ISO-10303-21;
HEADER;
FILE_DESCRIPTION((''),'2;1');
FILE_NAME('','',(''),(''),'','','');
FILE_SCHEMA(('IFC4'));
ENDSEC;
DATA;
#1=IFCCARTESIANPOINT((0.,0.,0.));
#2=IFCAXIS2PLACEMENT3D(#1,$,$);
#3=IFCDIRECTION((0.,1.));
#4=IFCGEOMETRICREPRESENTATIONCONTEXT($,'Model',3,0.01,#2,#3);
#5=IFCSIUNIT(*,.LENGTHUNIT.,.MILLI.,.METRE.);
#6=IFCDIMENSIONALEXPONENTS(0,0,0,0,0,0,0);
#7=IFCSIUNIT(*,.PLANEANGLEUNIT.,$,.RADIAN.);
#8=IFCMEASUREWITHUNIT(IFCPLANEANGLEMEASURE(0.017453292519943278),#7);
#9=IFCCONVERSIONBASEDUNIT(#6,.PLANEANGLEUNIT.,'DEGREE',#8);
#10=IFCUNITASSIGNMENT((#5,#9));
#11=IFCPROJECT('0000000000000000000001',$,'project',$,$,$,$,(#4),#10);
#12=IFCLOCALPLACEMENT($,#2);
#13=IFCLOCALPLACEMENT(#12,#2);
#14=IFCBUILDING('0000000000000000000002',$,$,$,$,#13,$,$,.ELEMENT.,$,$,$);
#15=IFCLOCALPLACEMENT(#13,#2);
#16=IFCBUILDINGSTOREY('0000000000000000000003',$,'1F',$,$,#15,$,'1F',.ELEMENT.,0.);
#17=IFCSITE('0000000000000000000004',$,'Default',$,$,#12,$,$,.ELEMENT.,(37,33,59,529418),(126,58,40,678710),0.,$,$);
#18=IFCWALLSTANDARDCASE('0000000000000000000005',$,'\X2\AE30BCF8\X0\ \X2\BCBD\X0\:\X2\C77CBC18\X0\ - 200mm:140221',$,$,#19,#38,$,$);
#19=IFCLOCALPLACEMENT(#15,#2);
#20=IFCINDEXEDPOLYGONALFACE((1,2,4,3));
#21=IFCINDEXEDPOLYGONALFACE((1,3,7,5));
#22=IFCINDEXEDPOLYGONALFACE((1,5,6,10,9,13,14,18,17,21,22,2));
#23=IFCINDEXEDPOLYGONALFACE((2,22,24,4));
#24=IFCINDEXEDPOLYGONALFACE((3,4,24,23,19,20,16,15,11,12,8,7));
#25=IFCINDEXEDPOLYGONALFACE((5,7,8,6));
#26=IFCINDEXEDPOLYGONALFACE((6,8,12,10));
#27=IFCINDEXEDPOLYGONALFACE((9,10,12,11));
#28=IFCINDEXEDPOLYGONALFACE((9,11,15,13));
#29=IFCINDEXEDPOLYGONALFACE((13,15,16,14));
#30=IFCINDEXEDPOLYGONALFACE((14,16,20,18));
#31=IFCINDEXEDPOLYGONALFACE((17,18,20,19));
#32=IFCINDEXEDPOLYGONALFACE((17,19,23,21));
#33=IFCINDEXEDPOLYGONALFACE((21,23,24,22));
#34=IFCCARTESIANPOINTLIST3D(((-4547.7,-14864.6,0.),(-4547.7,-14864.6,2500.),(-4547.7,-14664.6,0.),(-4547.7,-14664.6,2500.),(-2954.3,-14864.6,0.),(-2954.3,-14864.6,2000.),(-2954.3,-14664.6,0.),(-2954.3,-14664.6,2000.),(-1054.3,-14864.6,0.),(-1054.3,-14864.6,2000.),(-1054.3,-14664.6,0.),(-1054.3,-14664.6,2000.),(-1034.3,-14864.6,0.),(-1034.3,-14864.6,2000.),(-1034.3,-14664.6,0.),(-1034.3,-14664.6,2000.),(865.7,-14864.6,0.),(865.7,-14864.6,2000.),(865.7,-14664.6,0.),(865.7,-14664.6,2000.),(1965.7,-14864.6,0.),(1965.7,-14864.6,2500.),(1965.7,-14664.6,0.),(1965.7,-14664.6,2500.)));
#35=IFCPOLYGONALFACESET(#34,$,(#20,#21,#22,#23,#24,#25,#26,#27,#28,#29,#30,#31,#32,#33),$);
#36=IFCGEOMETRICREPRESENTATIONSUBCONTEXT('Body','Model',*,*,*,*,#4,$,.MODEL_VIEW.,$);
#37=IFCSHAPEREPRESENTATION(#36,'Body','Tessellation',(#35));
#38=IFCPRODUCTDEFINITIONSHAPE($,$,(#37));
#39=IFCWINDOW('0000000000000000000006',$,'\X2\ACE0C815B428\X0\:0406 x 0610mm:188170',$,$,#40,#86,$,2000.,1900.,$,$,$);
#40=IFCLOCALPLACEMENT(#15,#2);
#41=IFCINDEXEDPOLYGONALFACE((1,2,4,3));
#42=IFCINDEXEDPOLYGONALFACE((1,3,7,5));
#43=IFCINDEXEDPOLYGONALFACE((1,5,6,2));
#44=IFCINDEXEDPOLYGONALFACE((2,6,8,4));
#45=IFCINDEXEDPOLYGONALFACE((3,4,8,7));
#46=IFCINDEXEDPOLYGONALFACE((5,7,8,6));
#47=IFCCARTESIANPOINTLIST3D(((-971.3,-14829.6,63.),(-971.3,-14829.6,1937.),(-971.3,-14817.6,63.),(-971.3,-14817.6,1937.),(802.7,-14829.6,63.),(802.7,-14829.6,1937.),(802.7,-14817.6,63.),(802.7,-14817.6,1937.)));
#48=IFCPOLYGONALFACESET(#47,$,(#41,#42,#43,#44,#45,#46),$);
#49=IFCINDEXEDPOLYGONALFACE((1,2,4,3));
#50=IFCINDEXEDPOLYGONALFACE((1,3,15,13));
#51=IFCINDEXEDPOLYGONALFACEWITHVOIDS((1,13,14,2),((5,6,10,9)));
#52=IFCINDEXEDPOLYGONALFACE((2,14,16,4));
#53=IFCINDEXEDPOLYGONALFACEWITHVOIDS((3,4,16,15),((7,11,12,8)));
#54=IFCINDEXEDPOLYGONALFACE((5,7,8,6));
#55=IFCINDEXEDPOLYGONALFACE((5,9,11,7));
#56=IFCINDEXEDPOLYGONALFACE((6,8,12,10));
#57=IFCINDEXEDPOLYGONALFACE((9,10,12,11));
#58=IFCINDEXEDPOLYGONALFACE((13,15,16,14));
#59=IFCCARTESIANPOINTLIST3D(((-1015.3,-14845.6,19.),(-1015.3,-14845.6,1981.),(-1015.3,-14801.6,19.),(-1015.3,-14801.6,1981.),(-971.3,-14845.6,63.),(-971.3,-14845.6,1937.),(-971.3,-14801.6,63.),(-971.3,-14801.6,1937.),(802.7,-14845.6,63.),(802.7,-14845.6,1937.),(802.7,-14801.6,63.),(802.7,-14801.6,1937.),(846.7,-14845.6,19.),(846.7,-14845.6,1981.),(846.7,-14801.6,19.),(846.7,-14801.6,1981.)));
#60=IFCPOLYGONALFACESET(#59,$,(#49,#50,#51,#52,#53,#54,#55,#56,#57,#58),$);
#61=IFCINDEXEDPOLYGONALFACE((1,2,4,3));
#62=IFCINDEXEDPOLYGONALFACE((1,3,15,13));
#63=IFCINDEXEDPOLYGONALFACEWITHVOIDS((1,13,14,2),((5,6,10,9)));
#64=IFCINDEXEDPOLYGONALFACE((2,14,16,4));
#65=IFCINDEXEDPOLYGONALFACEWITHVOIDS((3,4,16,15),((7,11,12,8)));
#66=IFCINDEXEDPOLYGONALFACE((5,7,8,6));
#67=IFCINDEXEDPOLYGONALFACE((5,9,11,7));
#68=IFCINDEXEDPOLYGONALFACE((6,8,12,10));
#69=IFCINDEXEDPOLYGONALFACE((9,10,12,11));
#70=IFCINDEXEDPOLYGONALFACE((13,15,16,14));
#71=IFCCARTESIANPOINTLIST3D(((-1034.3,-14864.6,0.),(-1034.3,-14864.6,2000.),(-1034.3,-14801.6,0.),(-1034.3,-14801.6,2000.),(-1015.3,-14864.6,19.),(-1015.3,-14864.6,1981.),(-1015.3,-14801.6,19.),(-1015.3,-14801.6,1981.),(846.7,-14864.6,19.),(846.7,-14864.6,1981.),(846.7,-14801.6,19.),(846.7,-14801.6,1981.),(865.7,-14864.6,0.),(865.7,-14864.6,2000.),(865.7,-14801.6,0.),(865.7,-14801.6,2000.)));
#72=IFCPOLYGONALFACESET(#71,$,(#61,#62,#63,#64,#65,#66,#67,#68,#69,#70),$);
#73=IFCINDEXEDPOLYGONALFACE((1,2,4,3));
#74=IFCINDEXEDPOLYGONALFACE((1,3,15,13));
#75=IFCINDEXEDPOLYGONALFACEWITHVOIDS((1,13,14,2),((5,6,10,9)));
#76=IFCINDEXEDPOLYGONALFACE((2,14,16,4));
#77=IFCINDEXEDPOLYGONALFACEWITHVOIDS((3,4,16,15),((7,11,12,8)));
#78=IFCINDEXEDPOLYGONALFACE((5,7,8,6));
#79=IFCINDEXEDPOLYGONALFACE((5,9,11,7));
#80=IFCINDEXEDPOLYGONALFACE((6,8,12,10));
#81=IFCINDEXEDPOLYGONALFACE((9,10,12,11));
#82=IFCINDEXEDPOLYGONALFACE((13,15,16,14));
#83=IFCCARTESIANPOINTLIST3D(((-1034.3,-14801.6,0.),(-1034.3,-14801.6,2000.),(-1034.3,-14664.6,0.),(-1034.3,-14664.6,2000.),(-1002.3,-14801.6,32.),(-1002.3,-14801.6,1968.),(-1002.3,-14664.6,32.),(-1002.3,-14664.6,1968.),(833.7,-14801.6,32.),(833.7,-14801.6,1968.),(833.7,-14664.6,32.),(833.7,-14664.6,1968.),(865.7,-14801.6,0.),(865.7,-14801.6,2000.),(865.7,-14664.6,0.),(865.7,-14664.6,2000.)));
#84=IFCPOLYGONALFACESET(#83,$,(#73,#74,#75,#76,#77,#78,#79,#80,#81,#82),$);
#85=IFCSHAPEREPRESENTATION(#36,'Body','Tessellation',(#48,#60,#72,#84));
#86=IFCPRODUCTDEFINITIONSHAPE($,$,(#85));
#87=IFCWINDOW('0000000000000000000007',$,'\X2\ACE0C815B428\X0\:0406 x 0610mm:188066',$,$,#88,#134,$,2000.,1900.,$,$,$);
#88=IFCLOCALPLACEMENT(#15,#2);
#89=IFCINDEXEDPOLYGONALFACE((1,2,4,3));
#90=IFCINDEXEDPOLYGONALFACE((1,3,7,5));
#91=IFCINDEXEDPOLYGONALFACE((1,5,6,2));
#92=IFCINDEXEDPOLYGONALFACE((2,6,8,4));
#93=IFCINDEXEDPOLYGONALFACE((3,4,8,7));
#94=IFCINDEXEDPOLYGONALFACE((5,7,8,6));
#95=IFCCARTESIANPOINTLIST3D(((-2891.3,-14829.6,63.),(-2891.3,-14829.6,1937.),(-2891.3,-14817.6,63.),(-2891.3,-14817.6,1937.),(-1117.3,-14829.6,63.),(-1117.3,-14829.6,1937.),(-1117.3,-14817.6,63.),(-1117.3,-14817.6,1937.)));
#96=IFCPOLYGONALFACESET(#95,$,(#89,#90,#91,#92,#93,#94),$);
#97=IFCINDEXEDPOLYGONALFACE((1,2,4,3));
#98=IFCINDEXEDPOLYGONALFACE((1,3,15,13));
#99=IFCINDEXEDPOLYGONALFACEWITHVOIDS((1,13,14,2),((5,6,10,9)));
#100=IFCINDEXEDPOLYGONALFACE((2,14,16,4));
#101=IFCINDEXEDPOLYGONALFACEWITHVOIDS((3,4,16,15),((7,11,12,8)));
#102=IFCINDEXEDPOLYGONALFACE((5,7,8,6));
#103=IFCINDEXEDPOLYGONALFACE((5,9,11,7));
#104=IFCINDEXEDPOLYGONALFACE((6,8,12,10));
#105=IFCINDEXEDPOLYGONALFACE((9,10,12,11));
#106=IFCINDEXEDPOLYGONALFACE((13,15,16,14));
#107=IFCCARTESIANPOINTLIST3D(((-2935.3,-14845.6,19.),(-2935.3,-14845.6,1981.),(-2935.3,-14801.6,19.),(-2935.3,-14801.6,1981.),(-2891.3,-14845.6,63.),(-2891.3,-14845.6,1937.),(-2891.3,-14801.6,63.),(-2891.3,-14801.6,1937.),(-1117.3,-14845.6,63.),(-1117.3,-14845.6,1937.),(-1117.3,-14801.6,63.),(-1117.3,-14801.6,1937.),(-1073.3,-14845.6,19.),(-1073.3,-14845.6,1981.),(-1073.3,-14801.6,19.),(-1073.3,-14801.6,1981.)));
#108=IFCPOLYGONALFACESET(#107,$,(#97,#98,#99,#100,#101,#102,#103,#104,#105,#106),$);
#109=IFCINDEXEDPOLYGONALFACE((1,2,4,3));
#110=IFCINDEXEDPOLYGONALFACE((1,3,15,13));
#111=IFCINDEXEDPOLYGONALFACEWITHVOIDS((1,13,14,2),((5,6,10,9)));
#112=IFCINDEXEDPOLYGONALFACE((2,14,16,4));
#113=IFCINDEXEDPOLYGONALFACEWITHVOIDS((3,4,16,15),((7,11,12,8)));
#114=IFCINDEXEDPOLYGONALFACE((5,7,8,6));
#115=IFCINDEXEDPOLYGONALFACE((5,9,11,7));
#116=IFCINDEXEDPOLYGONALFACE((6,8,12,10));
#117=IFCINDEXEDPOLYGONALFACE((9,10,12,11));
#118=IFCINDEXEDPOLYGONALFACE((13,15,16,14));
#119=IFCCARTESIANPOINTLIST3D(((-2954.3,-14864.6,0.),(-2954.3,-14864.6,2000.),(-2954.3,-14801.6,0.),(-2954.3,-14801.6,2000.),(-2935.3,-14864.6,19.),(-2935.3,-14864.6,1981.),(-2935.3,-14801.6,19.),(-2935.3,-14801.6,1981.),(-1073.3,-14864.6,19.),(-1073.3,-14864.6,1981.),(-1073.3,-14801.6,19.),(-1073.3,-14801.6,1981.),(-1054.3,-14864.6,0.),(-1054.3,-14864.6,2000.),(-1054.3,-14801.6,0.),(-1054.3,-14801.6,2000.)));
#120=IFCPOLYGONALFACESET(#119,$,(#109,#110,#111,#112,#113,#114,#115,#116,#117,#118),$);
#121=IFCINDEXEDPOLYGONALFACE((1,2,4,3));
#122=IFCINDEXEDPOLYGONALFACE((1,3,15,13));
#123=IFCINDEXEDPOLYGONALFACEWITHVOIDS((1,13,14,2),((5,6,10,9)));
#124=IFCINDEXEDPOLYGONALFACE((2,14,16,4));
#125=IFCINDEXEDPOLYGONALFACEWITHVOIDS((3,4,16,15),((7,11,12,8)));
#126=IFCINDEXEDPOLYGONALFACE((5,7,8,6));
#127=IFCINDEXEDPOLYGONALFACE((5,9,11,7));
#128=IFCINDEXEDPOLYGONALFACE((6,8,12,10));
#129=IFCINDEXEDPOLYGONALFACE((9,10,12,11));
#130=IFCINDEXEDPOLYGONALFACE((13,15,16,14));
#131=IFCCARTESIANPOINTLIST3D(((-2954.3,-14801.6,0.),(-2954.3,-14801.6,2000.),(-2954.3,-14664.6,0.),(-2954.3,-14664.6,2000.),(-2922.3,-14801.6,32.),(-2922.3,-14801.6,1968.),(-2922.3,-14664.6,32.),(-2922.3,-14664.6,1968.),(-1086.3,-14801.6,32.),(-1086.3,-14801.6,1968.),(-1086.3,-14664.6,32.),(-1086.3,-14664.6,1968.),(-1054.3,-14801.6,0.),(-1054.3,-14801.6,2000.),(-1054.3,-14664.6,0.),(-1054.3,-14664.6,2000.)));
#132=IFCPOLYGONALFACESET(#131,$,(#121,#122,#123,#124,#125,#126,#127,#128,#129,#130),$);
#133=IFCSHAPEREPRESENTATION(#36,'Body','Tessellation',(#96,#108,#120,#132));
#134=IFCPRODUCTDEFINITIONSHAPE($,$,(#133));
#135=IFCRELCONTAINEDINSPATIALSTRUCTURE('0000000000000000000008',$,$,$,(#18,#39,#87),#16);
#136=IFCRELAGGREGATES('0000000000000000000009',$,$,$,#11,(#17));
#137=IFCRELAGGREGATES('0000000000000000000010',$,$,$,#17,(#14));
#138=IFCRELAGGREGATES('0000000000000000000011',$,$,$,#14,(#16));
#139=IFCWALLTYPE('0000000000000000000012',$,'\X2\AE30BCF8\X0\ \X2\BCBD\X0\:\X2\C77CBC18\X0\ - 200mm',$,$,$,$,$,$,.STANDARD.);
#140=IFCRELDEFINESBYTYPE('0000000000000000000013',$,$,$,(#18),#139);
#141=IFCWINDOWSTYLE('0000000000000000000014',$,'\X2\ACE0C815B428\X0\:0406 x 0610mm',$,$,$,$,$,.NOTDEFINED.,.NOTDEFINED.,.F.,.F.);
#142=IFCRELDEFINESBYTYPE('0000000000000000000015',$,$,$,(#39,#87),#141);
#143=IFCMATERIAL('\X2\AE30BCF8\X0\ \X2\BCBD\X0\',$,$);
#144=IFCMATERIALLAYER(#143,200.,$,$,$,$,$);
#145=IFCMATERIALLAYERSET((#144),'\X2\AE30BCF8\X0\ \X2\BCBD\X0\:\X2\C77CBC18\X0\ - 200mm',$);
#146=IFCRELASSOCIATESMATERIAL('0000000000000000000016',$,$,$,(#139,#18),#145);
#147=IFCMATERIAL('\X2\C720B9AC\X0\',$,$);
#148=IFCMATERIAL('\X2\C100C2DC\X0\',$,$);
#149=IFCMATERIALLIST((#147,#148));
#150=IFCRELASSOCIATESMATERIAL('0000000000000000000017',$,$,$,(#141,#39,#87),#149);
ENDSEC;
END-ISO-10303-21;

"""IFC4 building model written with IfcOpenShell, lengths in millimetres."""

from ifc_helpers import new_model, entity, si_unit, converted_unit, direction, frame, frame_2d, origin, place, context, subcontext, project, spatial, polyline, rectangle, outline, extrude, source, transform, mapped, material, material_list, layer, layer_set, layer_usage, type_object, type_shapes, element, fill, save


model = new_model("IFC4")

# Units and contexts
model_context = context("Model", 3, precision=0.01, world=origin(), true_north=direction((0.0, 1.0)))
body_context = subcontext(model_context, "Body", "Model", "MODEL_VIEW")
ifc_project = project(units=[si_unit("LENGTHUNIT", "METRE", prefix="MILLI"), converted_unit("PLANEANGLEUNIT", "DEGREE", entity("IfcPlaneAngleMeasure", 0.017453292519943278), si_unit("PLANEANGLEUNIT", "RADIAN"), dimensions=[0, 0, 0, 0, 0, 0, 0])], contexts=[model_context])

# Site, building, storey
site_placement = place(None, origin())
site = spatial("IfcSite", under=ifc_project, at=site_placement, Name="Default", CompositionType="ELEMENT", RefLatitude=(37, 33, 59, 529418), RefLongitude=(126, 58, 40, 678710), RefElevation=0.0)
building_placement = place(site_placement, origin())
building = spatial("IfcBuilding", under=site, at=building_placement, CompositionType="ELEMENT")
storey_placement = place(building_placement, origin())
storey = spatial("IfcBuildingStorey", under=building, at=storey_placement, Name="1F", LongName="1F", CompositionType="ELEMENT", Elevation=0.0)

# Shared definitions
ifc_material_1 = material(Name="기본 벽")
ifc_layer = layer(ifc_material_1, 200.0)
ifc_layer_set = layer_set([ifc_layer], Name="기본 벽:일반 - 200mm")
wall_type = type_object("IfcWallType", Name="기본 벽:일반 - 200mm", PredefinedType="STANDARD", material=ifc_layer_set)
ifc_material_2 = material(Name="유리")
ifc_material_3 = material(Name="섀시")
ifc_material_list_1 = material_list([ifc_material_2, ifc_material_3])

# Wall, openings, windows
ifc_layer_usage_1 = layer_usage(ifc_layer_set, "AXIS2", "NEGATIVE", 100.0)
wall_1_placement = place(storey_placement, frame((1965.7, -14764.6, 0.0), z_axis=(0.0, 0.0, 1.0), x_axis=(-1.0, 0.0, 0.0)))
wall_1 = element("IfcWallStandardCase", 1, at=wall_1_placement, inside=storey, type_object=wall_type, material=ifc_layer_usage_1, Name="기본 벽:일반 - 200mm:140221", context=body_context, shape_type="SweptSolid", body=[
    extrude(rectangle(XDim=6513.5, YDim=200.0, at=frame_2d((3256.7, 0.0), x_axis=(-1.0, 0.0))), origin(), (0.0, 0.0, 1.0), 2500.0),
])
opening_1_placement = place(wall_1_placement, frame((1100.0, -100.0, 0.0)))
opening_1 = element("IfcOpeningElement", 2, at=opening_1_placement, cuts=wall_1, ObjectType="Opening", context=body_context, shape_type="SweptSolid", body=[
    extrude(rectangle(XDim=2000.0, YDim=1900.0, at=frame_2d((1000.0, 950.0), x_axis=(1.0, 0.0))), frame((0.0, 0.0, 0.0), z_axis=(0.0, 1.0, 0.0), x_axis=(0.0, 0.0, 1.0)), (0.0, 0.0, 1.0), 200.0),
])
opening_2_placement = place(wall_1_placement, frame((3020.0, -100.0, 0.0)))
opening_2 = element("IfcOpeningElement", 3, at=opening_2_placement, cuts=wall_1, ObjectType="Opening", context=body_context, shape_type="SweptSolid", body=[
    extrude(rectangle(XDim=2000.0, YDim=1900.0, at=frame_2d((1000.0, 950.0), x_axis=(1.0, 0.0))), frame((0.0, 0.0, 0.0), z_axis=(0.0, 1.0, 0.0), x_axis=(0.0, 0.0, 1.0)), (0.0, 0.0, 1.0), 200.0),
])
window_style_1 = type_object("IfcWindowStyle", Name="고정됨:0406 x 0610mm", ConstructionType="NOTDEFINED", OperationType="NOTDEFINED", ParameterTakesPrecedence=False, Sizeable=False, material=ifc_material_list_1)
shared_shape_1 = source(origin(), body_context, "Body", "SweptSolid", [
    extrude(rectangle(XDim=12.0, YDim=1774.0, at=frame_2d((0.0, 0.0), x_axis=(1.0, 0.0))), frame((950.0, 159.0, 63.0), z_axis=(0.0, 0.0, 1.0), x_axis=(0.0, -1.0, 0.0)), (0.0, 0.0, 1.0), 1874.0),
    extrude(outline(polyline([(-931.0, -981.0), (931.0, -981.0), (931.0, 981.0), (-931.0, 981.0), (-931.0, -981.0)]), holes=[polyline([(-887.0, -937.0), (-887.0, 937.0), (887.0, 937.0), (887.0, -937.0), (-887.0, -937.0)])]), frame((950.0, 137.0, 1000.0), z_axis=(0.0, 1.0, 0.0), x_axis=(1.0, 0.0, 0.0)), (0.0, 0.0, 1.0), 44.0),
    extrude(outline(polyline([(-950.0, -1000.0), (950.0, -1000.0), (950.0, 1000.0), (-950.0, 1000.0), (-950.0, -1000.0)]), holes=[polyline([(-931.0, -981.0), (-931.0, 981.0), (931.0, 981.0), (931.0, -981.0), (-931.0, -981.0)])]), frame((950.0, 137.0, 1000.0), z_axis=(0.0, 1.0, 0.0), x_axis=(1.0, 0.0, 0.0)), (0.0, 0.0, 1.0), 63.0),
    extrude(outline(polyline([(-950.0, -1000.0), (950.0, -1000.0), (950.0, 1000.0), (-950.0, 1000.0), (-950.0, -1000.0)]), holes=[polyline([(-918.0, -968.0), (-918.0, 968.0), (918.0, 968.0), (918.0, -968.0), (-918.0, -968.0)])]), frame((950.0, 0.0, 1000.0), z_axis=(0.0, 1.0, 0.0), x_axis=(1.0, 0.0, 0.0)), (0.0, 0.0, 1.0), 137.0),
])
type_shapes(window_style_1, [shared_shape_1])
window_1_placement = place(opening_1_placement, origin())
window_1 = element("IfcWindow", 4, at=window_1_placement, inside=storey, type_object=window_style_1, material=ifc_material_list_1, Name="고정됨:0406 x 0610mm:188170", OverallHeight=2000.0, OverallWidth=1900.0, context=body_context, shape_type="MappedRepresentation", body=[
    mapped(shared_shape_1, transform((0.0, 0.0, 0.0), scale=1.0)),
])
fill(opening_1, window_1)
window_2_placement = place(opening_2_placement, origin())
window_2 = element("IfcWindow", 5, at=window_2_placement, inside=storey, type_object=window_style_1, material=ifc_material_list_1, Name="고정됨:0406 x 0610mm:188066", OverallHeight=2000.0, OverallWidth=1900.0, context=body_context, shape_type="MappedRepresentation", body=[
    mapped(shared_shape_1, transform((0.0, 0.0, 0.0), scale=1.0)),
])
fill(opening_2, window_2)

save(model, "model.ifc")
